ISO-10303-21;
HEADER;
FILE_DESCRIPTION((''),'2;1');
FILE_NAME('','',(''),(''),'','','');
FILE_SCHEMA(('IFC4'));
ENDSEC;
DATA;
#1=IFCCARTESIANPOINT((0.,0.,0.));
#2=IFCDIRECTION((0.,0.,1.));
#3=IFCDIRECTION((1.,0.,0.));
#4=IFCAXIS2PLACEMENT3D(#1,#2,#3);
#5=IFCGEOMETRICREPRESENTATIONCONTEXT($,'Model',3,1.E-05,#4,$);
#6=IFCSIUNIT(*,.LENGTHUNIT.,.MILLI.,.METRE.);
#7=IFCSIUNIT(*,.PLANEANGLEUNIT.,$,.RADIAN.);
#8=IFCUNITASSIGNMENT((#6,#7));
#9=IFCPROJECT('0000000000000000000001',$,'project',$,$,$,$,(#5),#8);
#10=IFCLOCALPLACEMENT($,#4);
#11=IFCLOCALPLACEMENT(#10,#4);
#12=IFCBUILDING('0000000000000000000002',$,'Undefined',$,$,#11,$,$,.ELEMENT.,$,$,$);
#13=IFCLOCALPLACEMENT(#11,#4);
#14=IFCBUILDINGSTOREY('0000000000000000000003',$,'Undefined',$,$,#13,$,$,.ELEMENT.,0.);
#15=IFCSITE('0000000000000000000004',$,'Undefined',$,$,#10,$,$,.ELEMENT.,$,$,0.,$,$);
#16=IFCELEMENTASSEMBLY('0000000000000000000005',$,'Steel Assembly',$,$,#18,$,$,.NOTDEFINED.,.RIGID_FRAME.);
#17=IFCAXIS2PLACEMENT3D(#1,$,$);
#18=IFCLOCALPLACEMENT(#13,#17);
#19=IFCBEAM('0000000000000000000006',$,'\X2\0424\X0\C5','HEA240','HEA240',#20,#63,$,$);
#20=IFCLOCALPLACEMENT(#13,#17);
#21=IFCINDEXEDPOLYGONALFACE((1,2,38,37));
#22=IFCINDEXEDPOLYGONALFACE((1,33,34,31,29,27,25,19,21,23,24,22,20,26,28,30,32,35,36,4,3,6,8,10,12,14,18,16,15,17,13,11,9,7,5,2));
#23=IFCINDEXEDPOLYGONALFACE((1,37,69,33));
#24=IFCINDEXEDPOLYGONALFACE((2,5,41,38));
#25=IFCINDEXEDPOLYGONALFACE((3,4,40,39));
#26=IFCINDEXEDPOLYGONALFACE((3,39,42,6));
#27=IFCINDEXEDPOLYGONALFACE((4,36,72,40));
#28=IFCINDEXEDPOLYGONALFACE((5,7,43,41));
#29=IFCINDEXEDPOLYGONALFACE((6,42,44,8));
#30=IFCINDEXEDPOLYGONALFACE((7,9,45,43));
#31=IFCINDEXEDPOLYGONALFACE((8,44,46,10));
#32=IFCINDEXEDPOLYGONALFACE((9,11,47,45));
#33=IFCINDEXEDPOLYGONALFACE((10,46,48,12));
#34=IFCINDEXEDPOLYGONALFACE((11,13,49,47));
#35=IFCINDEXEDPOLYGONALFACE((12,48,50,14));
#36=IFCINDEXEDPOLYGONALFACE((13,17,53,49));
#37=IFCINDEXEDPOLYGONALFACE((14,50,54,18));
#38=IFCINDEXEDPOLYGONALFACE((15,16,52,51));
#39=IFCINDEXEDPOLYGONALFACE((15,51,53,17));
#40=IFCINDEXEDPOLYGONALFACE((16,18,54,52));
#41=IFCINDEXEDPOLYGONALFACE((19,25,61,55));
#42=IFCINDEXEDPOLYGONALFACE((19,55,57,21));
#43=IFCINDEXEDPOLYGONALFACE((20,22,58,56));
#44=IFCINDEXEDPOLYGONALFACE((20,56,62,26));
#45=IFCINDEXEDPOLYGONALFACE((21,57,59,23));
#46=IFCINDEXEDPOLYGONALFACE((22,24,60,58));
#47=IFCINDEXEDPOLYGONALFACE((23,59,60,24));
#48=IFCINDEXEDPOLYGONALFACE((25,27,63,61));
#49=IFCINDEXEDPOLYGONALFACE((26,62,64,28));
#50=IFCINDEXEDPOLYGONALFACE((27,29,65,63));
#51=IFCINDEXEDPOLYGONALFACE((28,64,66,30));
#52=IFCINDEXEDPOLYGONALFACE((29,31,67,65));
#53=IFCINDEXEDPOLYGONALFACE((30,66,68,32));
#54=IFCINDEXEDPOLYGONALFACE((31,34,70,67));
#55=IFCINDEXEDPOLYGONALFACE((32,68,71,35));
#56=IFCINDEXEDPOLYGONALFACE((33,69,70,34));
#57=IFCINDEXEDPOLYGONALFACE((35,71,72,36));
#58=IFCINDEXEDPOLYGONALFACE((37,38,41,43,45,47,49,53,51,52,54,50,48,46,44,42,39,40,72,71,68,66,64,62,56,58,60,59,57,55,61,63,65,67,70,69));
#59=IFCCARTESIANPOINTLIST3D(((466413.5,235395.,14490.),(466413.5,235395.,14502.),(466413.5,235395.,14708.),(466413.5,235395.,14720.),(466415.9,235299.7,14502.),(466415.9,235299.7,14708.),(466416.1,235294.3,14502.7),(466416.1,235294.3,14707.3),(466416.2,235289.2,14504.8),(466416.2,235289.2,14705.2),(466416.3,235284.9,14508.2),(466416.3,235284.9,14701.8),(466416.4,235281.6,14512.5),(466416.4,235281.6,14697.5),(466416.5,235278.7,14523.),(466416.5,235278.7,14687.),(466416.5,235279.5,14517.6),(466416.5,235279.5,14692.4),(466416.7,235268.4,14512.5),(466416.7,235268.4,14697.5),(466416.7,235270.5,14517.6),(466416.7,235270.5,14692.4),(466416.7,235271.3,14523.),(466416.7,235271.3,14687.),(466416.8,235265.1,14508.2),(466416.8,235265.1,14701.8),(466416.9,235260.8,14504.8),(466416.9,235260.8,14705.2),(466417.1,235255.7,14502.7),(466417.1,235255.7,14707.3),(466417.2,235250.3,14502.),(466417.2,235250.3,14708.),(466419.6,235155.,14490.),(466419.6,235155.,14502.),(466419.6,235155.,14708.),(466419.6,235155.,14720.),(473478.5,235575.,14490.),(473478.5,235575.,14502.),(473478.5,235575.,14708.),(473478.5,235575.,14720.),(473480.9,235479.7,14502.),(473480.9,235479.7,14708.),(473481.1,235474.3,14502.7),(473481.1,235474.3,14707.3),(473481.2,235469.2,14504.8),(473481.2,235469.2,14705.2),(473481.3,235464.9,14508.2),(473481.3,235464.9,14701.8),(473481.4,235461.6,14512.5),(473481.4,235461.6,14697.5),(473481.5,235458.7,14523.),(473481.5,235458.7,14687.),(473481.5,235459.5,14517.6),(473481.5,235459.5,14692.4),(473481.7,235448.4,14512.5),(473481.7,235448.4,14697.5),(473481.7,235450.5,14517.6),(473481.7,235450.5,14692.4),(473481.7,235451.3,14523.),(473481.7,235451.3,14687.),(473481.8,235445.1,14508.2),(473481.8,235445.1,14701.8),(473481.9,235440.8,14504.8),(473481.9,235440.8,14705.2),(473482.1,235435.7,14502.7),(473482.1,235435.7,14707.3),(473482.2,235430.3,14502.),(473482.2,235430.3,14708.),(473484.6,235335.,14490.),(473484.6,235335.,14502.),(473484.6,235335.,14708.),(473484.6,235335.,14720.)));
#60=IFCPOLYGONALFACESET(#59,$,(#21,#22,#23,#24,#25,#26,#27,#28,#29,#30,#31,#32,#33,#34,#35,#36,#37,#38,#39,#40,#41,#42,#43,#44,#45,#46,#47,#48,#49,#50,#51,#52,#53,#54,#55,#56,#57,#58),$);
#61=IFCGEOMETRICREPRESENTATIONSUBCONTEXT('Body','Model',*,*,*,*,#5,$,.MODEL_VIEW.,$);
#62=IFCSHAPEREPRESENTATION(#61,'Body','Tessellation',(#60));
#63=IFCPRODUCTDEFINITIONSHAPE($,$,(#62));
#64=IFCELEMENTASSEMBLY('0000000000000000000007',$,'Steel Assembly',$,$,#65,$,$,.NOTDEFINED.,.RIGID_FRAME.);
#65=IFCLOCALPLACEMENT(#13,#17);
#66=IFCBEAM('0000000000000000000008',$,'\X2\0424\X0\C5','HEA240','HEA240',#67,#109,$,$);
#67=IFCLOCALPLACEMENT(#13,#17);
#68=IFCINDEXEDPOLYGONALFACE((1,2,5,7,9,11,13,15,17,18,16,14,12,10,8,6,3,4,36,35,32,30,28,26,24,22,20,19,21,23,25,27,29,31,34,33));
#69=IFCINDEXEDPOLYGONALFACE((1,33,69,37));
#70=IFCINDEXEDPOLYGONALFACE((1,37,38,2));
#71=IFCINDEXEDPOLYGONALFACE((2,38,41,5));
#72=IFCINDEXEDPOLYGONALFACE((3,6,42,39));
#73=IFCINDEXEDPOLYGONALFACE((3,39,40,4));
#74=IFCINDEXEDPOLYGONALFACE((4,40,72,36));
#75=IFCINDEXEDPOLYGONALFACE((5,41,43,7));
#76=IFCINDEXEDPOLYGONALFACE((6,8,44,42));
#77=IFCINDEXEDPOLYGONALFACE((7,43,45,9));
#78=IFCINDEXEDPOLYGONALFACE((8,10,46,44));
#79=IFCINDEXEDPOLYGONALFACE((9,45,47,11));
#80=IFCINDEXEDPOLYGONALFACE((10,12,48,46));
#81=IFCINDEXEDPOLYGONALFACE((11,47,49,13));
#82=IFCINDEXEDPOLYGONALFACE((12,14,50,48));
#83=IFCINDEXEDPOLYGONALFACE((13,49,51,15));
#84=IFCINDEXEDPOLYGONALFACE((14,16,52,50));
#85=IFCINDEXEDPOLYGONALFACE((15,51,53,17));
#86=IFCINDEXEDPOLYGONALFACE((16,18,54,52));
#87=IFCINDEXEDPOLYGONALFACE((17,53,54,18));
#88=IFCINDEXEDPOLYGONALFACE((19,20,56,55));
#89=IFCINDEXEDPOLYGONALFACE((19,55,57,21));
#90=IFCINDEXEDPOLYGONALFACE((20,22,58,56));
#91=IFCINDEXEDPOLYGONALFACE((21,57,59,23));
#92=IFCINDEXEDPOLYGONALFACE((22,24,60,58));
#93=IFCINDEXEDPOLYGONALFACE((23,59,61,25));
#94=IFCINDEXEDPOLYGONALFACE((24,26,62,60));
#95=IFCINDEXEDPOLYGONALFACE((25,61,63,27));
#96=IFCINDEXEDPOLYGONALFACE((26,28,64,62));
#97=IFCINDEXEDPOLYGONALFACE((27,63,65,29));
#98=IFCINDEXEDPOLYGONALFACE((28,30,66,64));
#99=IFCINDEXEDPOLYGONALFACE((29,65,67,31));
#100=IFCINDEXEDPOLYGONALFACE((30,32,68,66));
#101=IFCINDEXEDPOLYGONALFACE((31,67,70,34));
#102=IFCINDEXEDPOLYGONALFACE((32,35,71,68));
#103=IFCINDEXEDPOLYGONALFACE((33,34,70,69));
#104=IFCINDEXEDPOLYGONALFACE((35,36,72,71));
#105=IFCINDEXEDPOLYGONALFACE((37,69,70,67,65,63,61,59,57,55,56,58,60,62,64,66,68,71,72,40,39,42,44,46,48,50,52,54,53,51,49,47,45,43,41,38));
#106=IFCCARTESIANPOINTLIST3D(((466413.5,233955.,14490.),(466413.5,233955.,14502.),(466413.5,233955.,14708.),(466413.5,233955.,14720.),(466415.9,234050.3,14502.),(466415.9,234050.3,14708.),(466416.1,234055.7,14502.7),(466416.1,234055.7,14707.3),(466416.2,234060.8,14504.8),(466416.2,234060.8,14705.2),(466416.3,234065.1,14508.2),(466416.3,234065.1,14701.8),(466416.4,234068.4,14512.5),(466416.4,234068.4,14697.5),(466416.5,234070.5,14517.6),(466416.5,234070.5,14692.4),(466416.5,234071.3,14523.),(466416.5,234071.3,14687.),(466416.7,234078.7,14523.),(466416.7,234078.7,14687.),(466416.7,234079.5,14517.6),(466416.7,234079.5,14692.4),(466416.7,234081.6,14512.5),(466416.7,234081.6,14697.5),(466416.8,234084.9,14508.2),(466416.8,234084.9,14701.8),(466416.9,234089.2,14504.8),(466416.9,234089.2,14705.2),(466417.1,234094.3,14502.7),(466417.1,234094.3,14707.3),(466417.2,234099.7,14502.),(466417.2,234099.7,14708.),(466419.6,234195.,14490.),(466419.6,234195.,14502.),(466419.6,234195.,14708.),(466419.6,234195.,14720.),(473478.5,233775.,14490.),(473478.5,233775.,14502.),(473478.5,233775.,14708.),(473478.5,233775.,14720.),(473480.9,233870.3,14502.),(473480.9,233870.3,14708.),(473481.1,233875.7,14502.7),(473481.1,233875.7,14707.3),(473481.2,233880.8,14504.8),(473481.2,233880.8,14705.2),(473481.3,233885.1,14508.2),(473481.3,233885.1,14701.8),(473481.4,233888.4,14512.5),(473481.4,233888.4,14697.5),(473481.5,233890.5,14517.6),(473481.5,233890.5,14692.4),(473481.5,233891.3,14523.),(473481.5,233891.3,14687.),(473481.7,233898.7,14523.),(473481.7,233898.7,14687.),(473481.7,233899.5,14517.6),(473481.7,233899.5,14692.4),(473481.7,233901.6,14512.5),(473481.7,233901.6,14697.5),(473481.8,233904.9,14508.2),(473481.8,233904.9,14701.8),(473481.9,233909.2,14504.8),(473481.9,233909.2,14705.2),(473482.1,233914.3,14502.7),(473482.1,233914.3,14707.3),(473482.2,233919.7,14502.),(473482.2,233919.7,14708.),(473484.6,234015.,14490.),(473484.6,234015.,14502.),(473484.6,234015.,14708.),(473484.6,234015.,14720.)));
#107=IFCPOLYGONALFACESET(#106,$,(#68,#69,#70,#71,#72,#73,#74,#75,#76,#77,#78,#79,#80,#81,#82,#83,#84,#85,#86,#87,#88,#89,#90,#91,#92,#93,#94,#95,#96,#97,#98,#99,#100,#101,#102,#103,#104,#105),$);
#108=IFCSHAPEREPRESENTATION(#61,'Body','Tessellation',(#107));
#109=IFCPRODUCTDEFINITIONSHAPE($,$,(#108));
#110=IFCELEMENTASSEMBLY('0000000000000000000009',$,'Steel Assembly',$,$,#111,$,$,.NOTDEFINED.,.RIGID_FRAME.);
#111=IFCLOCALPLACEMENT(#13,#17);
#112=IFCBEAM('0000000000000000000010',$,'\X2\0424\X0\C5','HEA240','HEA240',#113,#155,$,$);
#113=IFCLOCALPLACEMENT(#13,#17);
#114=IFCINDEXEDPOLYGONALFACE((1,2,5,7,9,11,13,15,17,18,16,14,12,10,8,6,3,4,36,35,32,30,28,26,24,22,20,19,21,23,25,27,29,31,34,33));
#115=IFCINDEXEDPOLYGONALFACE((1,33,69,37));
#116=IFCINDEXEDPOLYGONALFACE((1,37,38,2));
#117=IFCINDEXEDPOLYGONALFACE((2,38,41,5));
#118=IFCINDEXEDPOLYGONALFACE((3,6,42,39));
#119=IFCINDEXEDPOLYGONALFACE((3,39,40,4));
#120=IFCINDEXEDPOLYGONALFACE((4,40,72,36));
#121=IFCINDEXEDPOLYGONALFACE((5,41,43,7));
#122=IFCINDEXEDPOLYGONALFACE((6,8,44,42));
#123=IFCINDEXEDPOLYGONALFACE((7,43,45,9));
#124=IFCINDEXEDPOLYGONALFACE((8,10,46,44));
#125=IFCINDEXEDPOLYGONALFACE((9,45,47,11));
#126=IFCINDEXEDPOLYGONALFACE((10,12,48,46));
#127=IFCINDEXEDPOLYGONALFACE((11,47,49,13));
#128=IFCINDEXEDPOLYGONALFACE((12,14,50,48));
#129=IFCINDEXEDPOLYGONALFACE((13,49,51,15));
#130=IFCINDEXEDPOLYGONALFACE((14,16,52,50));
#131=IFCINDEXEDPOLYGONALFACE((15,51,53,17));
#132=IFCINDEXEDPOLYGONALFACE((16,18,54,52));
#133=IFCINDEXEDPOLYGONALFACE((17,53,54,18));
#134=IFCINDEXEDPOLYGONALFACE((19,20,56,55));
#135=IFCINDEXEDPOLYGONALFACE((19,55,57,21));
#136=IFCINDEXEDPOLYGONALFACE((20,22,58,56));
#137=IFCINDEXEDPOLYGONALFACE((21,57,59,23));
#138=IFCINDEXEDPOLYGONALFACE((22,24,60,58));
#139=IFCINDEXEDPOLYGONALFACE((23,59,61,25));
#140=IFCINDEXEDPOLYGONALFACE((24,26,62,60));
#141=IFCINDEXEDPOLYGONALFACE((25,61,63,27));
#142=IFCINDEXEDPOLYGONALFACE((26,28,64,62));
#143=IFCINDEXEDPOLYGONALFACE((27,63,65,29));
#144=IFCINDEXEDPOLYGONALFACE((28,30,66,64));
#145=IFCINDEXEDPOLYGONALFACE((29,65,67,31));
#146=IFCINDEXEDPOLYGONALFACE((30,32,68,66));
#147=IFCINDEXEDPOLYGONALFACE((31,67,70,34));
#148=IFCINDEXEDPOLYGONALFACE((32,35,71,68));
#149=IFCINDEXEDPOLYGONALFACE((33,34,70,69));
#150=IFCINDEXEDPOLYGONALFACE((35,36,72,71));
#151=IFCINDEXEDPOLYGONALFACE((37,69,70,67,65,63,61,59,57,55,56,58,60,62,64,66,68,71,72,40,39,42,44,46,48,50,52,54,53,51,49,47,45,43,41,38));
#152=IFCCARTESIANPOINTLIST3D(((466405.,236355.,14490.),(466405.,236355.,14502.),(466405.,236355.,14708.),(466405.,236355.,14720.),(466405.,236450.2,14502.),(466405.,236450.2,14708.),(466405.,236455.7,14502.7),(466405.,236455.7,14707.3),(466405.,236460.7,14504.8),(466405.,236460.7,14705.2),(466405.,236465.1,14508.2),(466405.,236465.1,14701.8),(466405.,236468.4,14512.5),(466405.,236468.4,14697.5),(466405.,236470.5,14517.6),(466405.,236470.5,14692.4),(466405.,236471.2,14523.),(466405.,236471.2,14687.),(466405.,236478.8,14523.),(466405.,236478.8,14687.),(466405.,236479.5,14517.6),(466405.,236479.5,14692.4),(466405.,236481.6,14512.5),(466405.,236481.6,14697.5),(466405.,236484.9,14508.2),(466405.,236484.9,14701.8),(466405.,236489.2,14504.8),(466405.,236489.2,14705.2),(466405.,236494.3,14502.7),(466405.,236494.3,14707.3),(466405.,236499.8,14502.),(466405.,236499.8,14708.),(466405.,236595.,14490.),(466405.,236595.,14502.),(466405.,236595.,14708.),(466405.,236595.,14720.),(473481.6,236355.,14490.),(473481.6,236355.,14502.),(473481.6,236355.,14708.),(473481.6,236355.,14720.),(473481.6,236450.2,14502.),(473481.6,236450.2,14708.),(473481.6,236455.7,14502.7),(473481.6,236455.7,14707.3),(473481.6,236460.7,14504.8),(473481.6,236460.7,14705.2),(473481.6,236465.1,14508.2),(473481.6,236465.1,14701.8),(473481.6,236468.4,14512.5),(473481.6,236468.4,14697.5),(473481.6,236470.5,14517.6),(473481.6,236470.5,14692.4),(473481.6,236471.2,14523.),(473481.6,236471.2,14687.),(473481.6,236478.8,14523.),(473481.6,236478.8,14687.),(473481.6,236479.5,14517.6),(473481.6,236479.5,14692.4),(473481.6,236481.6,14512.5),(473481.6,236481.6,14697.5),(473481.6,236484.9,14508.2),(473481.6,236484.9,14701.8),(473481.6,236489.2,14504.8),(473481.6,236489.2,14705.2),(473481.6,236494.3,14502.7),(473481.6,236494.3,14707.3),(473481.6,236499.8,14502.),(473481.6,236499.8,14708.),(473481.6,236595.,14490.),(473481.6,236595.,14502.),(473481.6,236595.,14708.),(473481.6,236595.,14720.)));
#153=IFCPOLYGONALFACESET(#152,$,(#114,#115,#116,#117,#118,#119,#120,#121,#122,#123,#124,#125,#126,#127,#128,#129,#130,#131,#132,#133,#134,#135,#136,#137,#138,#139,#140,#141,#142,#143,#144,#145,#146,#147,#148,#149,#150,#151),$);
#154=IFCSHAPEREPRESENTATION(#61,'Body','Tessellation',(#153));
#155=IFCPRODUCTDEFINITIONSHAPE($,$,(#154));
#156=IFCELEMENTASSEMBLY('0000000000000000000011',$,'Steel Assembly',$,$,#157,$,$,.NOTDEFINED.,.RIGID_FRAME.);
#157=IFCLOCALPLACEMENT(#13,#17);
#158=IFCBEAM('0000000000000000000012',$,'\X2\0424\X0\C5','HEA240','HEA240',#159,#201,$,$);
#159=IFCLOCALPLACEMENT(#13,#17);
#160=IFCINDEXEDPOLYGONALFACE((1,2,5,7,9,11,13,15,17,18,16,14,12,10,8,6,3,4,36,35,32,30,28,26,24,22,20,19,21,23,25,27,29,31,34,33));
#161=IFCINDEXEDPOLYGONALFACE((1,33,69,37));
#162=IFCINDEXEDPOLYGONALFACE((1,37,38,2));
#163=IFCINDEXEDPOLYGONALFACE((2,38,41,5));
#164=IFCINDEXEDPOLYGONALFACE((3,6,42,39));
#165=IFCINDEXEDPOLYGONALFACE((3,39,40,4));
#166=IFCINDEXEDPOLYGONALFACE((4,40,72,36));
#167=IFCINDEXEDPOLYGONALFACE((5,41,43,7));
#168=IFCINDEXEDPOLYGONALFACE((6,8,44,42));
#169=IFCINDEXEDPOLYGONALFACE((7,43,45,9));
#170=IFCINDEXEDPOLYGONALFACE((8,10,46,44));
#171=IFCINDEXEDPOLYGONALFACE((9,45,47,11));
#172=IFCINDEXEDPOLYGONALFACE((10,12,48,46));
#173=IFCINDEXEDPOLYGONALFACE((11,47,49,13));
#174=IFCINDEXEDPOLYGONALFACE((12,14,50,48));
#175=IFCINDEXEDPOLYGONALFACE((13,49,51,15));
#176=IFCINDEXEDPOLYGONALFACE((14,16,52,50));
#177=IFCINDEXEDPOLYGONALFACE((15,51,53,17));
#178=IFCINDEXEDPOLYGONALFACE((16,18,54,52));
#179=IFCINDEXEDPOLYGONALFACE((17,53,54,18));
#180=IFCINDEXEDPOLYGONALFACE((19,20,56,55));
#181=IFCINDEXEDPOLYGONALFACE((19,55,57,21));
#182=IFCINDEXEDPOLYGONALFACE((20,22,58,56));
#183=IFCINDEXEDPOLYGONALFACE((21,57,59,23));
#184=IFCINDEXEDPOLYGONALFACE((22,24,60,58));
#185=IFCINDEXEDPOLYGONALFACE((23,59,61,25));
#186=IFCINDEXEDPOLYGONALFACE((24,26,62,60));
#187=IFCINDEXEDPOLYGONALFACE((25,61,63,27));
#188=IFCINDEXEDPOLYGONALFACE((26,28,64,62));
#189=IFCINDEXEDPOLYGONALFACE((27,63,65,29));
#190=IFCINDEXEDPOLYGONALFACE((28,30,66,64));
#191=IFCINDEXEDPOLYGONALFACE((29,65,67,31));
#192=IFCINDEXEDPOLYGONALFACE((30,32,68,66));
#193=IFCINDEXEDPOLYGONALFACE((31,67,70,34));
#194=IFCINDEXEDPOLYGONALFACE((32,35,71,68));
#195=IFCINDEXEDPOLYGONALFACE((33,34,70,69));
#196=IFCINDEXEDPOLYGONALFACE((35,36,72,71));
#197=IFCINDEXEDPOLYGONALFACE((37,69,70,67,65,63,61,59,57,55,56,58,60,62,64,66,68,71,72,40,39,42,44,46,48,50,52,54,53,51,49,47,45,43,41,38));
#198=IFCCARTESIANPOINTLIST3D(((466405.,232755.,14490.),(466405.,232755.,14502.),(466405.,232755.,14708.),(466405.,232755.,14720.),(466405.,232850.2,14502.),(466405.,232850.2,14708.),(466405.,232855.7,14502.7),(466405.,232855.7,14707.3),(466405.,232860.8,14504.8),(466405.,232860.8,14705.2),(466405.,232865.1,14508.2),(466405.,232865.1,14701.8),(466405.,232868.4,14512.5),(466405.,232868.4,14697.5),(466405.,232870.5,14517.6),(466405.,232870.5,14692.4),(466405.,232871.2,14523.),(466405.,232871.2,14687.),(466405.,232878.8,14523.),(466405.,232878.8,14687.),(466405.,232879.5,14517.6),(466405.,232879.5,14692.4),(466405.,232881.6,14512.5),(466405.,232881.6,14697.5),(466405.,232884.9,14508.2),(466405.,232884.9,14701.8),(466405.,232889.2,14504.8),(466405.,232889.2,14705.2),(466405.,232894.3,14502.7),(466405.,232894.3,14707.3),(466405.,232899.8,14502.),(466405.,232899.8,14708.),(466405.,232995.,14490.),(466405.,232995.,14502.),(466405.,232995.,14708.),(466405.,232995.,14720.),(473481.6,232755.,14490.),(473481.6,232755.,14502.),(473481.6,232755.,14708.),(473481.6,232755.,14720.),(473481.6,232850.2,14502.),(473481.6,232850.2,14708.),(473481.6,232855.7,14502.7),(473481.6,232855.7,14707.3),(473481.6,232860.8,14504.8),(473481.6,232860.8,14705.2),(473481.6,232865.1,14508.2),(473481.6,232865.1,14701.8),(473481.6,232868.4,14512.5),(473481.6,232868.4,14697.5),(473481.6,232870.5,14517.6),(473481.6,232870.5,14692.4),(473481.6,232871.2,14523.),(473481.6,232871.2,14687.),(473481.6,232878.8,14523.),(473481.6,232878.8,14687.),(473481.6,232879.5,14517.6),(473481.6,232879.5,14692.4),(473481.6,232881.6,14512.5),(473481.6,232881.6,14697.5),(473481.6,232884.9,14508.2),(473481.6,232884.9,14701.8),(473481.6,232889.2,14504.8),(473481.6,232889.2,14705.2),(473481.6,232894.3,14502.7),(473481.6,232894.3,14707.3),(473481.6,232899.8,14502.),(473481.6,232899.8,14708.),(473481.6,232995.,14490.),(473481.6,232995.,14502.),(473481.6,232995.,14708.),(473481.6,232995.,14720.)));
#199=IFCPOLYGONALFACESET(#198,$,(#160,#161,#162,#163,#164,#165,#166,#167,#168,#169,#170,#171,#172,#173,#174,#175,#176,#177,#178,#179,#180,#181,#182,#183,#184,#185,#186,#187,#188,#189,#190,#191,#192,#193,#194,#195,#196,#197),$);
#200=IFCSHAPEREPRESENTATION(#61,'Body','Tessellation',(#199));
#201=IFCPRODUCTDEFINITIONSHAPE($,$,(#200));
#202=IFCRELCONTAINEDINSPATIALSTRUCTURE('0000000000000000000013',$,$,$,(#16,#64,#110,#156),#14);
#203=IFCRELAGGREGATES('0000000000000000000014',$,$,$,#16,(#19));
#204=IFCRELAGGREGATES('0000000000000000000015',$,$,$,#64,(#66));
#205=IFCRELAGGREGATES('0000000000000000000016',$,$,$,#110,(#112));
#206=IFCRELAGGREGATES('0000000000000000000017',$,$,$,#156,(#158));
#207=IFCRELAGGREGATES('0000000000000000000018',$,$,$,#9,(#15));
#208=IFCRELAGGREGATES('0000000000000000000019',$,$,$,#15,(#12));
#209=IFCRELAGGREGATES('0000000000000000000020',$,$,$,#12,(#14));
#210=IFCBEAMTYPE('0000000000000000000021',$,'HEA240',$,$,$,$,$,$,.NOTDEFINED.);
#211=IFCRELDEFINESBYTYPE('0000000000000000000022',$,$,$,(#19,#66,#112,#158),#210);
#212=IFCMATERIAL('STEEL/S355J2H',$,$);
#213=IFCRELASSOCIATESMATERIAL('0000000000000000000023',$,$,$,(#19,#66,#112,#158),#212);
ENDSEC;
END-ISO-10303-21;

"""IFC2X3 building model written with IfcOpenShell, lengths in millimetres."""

from ifc_helpers import new_model, si_unit, frame, origin_with_axes, origin_2d_with_axis, place, context, subcontext, project, spatial, i_section, extrude, material, type_object, element, aggregate, save


model = new_model("IFC2X3")

# Units and contexts
model_context = context("Model", 3, precision=1e-05, world=origin_with_axes())
body_context = subcontext(model_context, "Body", "Model", "MODEL_VIEW")
ifc_project = project(units=[si_unit("LENGTHUNIT", "METRE", prefix="MILLI"), si_unit("PLANEANGLEUNIT", "RADIAN")], contexts=[model_context])

# Site, building, storey
site_placement = place(None, origin_with_axes())
site = spatial("IfcSite", under=ifc_project, at=site_placement, Name="Undefined", CompositionType="ELEMENT", RefElevation=0.0)
building_placement = place(site_placement, origin_with_axes())
building = spatial("IfcBuilding", under=site, at=building_placement, Name="Undefined", CompositionType="ELEMENT")
storey_placement = place(building_placement, origin_with_axes())
storey = spatial("IfcBuildingStorey", under=building, at=storey_placement, Name="Undefined", CompositionType="ELEMENT", Elevation=0.0)

# Element assemblies, beams
assembly_1_placement = place(storey_placement, origin_with_axes())
assembly_1 = element("IfcElementAssembly", 1, at=assembly_1_placement, inside=storey, Name="Steel Assembly", AssemblyPlace="NOTDEFINED", PredefinedType="RIGID_FRAME")
ifc_material_1 = material(Name="STEEL/S355J2H")
beam_type_1 = type_object("IfcBeamType", Name="HEA240", PredefinedType="NOTDEFINED")
beam_1_placement = place(assembly_1_placement, frame((466416.6, 235275.0, 14605.0), z_axis=(0.0, 0.0, 1.0), x_axis=(0.999676, 0.025469, 0.0)))
beam_1 = element("IfcBeam", 2, at=beam_1_placement, type_object=beam_type_1, material=ifc_material_1, Name="ФC5", Description="HEA240", ObjectType="HEA240", context=body_context, shape_type="SweptSolid", body=[
    extrude(i_section(OverallWidth=240.0, OverallDepth=230.0, WebThickness=7.5, FlangeThickness=12.0, FilletRadius=21.0, at=origin_2d_with_axis()), frame((7067.3, 0.0, 0.0), z_axis=(-1.0, 0.0, 0.0), x_axis=(0.0, -1.0, 0.0)), (0.0, 0.0, 1.0), 7067.3),
])
aggregate(assembly_1, [beam_1])
assembly_2_placement = place(storey_placement, origin_with_axes())
assembly_2 = element("IfcElementAssembly", 3, at=assembly_2_placement, inside=storey, Name="Steel Assembly", AssemblyPlace="NOTDEFINED", PredefinedType="RIGID_FRAME")
beam_2_placement = place(assembly_2_placement, frame((466416.6, 234075.0, 14605.0), z_axis=(0.0, 0.0, 1.0), x_axis=(0.999676, -0.025469, 0.0)))
beam_2 = element("IfcBeam", 4, at=beam_2_placement, type_object=beam_type_1, material=ifc_material_1, Name="ФC5", Description="HEA240", ObjectType="HEA240", context=body_context, shape_type="SweptSolid", body=[
    extrude(i_section(OverallWidth=240.0, OverallDepth=230.0, WebThickness=7.5, FlangeThickness=12.0, FilletRadius=21.0, at=origin_2d_with_axis()), frame((7067.3, 0.0, 0.0), z_axis=(-1.0, 0.0, 0.0), x_axis=(0.0, -1.0, 0.0)), (0.0, 0.0, 1.0), 7067.3),
])
aggregate(assembly_2, [beam_2])
assembly_3_placement = place(storey_placement, origin_with_axes())
assembly_3 = element("IfcElementAssembly", 5, at=assembly_3_placement, inside=storey, Name="Steel Assembly", AssemblyPlace="NOTDEFINED", PredefinedType="RIGID_FRAME")
beam_3_placement = place(assembly_3_placement, frame((466405.0, 236475.0, 14605.0), z_axis=(0.0, 0.0, 1.0), x_axis=(1.0, 0.0, 0.0)))
beam_3 = element("IfcBeam", 6, at=beam_3_placement, type_object=beam_type_1, material=ifc_material_1, Name="ФC5", Description="HEA240", ObjectType="HEA240", context=body_context, shape_type="SweptSolid", body=[
    extrude(i_section(OverallWidth=240.0, OverallDepth=230.0, WebThickness=7.5, FlangeThickness=12.0, FilletRadius=21.0, at=origin_2d_with_axis()), frame((7076.6, 0.0, 0.0), z_axis=(-1.0, 0.0, 0.0), x_axis=(0.0, -1.0, 0.0)), (0.0, 0.0, 1.0), 7076.6),
])
aggregate(assembly_3, [beam_3])
assembly_4_placement = place(storey_placement, origin_with_axes())
assembly_4 = element("IfcElementAssembly", 7, at=assembly_4_placement, inside=storey, Name="Steel Assembly", AssemblyPlace="NOTDEFINED", PredefinedType="RIGID_FRAME")
beam_4_placement = place(assembly_4_placement, frame((466405.0, 232875.0, 14605.0), z_axis=(0.0, 0.0, 1.0), x_axis=(1.0, 0.0, 0.0)))
beam_4 = element("IfcBeam", 8, at=beam_4_placement, type_object=beam_type_1, material=ifc_material_1, Name="ФC5", Description="HEA240", ObjectType="HEA240", context=body_context, shape_type="SweptSolid", body=[
    extrude(i_section(OverallWidth=240.0, OverallDepth=230.0, WebThickness=7.5, FlangeThickness=12.0, FilletRadius=21.0, at=origin_2d_with_axis()), frame((7076.6, 0.0, 0.0), z_axis=(-1.0, 0.0, 0.0), x_axis=(0.0, -1.0, 0.0)), (0.0, 0.0, 1.0), 7076.6),
])
aggregate(assembly_4, [beam_4])

save(model, "model.ifc")
